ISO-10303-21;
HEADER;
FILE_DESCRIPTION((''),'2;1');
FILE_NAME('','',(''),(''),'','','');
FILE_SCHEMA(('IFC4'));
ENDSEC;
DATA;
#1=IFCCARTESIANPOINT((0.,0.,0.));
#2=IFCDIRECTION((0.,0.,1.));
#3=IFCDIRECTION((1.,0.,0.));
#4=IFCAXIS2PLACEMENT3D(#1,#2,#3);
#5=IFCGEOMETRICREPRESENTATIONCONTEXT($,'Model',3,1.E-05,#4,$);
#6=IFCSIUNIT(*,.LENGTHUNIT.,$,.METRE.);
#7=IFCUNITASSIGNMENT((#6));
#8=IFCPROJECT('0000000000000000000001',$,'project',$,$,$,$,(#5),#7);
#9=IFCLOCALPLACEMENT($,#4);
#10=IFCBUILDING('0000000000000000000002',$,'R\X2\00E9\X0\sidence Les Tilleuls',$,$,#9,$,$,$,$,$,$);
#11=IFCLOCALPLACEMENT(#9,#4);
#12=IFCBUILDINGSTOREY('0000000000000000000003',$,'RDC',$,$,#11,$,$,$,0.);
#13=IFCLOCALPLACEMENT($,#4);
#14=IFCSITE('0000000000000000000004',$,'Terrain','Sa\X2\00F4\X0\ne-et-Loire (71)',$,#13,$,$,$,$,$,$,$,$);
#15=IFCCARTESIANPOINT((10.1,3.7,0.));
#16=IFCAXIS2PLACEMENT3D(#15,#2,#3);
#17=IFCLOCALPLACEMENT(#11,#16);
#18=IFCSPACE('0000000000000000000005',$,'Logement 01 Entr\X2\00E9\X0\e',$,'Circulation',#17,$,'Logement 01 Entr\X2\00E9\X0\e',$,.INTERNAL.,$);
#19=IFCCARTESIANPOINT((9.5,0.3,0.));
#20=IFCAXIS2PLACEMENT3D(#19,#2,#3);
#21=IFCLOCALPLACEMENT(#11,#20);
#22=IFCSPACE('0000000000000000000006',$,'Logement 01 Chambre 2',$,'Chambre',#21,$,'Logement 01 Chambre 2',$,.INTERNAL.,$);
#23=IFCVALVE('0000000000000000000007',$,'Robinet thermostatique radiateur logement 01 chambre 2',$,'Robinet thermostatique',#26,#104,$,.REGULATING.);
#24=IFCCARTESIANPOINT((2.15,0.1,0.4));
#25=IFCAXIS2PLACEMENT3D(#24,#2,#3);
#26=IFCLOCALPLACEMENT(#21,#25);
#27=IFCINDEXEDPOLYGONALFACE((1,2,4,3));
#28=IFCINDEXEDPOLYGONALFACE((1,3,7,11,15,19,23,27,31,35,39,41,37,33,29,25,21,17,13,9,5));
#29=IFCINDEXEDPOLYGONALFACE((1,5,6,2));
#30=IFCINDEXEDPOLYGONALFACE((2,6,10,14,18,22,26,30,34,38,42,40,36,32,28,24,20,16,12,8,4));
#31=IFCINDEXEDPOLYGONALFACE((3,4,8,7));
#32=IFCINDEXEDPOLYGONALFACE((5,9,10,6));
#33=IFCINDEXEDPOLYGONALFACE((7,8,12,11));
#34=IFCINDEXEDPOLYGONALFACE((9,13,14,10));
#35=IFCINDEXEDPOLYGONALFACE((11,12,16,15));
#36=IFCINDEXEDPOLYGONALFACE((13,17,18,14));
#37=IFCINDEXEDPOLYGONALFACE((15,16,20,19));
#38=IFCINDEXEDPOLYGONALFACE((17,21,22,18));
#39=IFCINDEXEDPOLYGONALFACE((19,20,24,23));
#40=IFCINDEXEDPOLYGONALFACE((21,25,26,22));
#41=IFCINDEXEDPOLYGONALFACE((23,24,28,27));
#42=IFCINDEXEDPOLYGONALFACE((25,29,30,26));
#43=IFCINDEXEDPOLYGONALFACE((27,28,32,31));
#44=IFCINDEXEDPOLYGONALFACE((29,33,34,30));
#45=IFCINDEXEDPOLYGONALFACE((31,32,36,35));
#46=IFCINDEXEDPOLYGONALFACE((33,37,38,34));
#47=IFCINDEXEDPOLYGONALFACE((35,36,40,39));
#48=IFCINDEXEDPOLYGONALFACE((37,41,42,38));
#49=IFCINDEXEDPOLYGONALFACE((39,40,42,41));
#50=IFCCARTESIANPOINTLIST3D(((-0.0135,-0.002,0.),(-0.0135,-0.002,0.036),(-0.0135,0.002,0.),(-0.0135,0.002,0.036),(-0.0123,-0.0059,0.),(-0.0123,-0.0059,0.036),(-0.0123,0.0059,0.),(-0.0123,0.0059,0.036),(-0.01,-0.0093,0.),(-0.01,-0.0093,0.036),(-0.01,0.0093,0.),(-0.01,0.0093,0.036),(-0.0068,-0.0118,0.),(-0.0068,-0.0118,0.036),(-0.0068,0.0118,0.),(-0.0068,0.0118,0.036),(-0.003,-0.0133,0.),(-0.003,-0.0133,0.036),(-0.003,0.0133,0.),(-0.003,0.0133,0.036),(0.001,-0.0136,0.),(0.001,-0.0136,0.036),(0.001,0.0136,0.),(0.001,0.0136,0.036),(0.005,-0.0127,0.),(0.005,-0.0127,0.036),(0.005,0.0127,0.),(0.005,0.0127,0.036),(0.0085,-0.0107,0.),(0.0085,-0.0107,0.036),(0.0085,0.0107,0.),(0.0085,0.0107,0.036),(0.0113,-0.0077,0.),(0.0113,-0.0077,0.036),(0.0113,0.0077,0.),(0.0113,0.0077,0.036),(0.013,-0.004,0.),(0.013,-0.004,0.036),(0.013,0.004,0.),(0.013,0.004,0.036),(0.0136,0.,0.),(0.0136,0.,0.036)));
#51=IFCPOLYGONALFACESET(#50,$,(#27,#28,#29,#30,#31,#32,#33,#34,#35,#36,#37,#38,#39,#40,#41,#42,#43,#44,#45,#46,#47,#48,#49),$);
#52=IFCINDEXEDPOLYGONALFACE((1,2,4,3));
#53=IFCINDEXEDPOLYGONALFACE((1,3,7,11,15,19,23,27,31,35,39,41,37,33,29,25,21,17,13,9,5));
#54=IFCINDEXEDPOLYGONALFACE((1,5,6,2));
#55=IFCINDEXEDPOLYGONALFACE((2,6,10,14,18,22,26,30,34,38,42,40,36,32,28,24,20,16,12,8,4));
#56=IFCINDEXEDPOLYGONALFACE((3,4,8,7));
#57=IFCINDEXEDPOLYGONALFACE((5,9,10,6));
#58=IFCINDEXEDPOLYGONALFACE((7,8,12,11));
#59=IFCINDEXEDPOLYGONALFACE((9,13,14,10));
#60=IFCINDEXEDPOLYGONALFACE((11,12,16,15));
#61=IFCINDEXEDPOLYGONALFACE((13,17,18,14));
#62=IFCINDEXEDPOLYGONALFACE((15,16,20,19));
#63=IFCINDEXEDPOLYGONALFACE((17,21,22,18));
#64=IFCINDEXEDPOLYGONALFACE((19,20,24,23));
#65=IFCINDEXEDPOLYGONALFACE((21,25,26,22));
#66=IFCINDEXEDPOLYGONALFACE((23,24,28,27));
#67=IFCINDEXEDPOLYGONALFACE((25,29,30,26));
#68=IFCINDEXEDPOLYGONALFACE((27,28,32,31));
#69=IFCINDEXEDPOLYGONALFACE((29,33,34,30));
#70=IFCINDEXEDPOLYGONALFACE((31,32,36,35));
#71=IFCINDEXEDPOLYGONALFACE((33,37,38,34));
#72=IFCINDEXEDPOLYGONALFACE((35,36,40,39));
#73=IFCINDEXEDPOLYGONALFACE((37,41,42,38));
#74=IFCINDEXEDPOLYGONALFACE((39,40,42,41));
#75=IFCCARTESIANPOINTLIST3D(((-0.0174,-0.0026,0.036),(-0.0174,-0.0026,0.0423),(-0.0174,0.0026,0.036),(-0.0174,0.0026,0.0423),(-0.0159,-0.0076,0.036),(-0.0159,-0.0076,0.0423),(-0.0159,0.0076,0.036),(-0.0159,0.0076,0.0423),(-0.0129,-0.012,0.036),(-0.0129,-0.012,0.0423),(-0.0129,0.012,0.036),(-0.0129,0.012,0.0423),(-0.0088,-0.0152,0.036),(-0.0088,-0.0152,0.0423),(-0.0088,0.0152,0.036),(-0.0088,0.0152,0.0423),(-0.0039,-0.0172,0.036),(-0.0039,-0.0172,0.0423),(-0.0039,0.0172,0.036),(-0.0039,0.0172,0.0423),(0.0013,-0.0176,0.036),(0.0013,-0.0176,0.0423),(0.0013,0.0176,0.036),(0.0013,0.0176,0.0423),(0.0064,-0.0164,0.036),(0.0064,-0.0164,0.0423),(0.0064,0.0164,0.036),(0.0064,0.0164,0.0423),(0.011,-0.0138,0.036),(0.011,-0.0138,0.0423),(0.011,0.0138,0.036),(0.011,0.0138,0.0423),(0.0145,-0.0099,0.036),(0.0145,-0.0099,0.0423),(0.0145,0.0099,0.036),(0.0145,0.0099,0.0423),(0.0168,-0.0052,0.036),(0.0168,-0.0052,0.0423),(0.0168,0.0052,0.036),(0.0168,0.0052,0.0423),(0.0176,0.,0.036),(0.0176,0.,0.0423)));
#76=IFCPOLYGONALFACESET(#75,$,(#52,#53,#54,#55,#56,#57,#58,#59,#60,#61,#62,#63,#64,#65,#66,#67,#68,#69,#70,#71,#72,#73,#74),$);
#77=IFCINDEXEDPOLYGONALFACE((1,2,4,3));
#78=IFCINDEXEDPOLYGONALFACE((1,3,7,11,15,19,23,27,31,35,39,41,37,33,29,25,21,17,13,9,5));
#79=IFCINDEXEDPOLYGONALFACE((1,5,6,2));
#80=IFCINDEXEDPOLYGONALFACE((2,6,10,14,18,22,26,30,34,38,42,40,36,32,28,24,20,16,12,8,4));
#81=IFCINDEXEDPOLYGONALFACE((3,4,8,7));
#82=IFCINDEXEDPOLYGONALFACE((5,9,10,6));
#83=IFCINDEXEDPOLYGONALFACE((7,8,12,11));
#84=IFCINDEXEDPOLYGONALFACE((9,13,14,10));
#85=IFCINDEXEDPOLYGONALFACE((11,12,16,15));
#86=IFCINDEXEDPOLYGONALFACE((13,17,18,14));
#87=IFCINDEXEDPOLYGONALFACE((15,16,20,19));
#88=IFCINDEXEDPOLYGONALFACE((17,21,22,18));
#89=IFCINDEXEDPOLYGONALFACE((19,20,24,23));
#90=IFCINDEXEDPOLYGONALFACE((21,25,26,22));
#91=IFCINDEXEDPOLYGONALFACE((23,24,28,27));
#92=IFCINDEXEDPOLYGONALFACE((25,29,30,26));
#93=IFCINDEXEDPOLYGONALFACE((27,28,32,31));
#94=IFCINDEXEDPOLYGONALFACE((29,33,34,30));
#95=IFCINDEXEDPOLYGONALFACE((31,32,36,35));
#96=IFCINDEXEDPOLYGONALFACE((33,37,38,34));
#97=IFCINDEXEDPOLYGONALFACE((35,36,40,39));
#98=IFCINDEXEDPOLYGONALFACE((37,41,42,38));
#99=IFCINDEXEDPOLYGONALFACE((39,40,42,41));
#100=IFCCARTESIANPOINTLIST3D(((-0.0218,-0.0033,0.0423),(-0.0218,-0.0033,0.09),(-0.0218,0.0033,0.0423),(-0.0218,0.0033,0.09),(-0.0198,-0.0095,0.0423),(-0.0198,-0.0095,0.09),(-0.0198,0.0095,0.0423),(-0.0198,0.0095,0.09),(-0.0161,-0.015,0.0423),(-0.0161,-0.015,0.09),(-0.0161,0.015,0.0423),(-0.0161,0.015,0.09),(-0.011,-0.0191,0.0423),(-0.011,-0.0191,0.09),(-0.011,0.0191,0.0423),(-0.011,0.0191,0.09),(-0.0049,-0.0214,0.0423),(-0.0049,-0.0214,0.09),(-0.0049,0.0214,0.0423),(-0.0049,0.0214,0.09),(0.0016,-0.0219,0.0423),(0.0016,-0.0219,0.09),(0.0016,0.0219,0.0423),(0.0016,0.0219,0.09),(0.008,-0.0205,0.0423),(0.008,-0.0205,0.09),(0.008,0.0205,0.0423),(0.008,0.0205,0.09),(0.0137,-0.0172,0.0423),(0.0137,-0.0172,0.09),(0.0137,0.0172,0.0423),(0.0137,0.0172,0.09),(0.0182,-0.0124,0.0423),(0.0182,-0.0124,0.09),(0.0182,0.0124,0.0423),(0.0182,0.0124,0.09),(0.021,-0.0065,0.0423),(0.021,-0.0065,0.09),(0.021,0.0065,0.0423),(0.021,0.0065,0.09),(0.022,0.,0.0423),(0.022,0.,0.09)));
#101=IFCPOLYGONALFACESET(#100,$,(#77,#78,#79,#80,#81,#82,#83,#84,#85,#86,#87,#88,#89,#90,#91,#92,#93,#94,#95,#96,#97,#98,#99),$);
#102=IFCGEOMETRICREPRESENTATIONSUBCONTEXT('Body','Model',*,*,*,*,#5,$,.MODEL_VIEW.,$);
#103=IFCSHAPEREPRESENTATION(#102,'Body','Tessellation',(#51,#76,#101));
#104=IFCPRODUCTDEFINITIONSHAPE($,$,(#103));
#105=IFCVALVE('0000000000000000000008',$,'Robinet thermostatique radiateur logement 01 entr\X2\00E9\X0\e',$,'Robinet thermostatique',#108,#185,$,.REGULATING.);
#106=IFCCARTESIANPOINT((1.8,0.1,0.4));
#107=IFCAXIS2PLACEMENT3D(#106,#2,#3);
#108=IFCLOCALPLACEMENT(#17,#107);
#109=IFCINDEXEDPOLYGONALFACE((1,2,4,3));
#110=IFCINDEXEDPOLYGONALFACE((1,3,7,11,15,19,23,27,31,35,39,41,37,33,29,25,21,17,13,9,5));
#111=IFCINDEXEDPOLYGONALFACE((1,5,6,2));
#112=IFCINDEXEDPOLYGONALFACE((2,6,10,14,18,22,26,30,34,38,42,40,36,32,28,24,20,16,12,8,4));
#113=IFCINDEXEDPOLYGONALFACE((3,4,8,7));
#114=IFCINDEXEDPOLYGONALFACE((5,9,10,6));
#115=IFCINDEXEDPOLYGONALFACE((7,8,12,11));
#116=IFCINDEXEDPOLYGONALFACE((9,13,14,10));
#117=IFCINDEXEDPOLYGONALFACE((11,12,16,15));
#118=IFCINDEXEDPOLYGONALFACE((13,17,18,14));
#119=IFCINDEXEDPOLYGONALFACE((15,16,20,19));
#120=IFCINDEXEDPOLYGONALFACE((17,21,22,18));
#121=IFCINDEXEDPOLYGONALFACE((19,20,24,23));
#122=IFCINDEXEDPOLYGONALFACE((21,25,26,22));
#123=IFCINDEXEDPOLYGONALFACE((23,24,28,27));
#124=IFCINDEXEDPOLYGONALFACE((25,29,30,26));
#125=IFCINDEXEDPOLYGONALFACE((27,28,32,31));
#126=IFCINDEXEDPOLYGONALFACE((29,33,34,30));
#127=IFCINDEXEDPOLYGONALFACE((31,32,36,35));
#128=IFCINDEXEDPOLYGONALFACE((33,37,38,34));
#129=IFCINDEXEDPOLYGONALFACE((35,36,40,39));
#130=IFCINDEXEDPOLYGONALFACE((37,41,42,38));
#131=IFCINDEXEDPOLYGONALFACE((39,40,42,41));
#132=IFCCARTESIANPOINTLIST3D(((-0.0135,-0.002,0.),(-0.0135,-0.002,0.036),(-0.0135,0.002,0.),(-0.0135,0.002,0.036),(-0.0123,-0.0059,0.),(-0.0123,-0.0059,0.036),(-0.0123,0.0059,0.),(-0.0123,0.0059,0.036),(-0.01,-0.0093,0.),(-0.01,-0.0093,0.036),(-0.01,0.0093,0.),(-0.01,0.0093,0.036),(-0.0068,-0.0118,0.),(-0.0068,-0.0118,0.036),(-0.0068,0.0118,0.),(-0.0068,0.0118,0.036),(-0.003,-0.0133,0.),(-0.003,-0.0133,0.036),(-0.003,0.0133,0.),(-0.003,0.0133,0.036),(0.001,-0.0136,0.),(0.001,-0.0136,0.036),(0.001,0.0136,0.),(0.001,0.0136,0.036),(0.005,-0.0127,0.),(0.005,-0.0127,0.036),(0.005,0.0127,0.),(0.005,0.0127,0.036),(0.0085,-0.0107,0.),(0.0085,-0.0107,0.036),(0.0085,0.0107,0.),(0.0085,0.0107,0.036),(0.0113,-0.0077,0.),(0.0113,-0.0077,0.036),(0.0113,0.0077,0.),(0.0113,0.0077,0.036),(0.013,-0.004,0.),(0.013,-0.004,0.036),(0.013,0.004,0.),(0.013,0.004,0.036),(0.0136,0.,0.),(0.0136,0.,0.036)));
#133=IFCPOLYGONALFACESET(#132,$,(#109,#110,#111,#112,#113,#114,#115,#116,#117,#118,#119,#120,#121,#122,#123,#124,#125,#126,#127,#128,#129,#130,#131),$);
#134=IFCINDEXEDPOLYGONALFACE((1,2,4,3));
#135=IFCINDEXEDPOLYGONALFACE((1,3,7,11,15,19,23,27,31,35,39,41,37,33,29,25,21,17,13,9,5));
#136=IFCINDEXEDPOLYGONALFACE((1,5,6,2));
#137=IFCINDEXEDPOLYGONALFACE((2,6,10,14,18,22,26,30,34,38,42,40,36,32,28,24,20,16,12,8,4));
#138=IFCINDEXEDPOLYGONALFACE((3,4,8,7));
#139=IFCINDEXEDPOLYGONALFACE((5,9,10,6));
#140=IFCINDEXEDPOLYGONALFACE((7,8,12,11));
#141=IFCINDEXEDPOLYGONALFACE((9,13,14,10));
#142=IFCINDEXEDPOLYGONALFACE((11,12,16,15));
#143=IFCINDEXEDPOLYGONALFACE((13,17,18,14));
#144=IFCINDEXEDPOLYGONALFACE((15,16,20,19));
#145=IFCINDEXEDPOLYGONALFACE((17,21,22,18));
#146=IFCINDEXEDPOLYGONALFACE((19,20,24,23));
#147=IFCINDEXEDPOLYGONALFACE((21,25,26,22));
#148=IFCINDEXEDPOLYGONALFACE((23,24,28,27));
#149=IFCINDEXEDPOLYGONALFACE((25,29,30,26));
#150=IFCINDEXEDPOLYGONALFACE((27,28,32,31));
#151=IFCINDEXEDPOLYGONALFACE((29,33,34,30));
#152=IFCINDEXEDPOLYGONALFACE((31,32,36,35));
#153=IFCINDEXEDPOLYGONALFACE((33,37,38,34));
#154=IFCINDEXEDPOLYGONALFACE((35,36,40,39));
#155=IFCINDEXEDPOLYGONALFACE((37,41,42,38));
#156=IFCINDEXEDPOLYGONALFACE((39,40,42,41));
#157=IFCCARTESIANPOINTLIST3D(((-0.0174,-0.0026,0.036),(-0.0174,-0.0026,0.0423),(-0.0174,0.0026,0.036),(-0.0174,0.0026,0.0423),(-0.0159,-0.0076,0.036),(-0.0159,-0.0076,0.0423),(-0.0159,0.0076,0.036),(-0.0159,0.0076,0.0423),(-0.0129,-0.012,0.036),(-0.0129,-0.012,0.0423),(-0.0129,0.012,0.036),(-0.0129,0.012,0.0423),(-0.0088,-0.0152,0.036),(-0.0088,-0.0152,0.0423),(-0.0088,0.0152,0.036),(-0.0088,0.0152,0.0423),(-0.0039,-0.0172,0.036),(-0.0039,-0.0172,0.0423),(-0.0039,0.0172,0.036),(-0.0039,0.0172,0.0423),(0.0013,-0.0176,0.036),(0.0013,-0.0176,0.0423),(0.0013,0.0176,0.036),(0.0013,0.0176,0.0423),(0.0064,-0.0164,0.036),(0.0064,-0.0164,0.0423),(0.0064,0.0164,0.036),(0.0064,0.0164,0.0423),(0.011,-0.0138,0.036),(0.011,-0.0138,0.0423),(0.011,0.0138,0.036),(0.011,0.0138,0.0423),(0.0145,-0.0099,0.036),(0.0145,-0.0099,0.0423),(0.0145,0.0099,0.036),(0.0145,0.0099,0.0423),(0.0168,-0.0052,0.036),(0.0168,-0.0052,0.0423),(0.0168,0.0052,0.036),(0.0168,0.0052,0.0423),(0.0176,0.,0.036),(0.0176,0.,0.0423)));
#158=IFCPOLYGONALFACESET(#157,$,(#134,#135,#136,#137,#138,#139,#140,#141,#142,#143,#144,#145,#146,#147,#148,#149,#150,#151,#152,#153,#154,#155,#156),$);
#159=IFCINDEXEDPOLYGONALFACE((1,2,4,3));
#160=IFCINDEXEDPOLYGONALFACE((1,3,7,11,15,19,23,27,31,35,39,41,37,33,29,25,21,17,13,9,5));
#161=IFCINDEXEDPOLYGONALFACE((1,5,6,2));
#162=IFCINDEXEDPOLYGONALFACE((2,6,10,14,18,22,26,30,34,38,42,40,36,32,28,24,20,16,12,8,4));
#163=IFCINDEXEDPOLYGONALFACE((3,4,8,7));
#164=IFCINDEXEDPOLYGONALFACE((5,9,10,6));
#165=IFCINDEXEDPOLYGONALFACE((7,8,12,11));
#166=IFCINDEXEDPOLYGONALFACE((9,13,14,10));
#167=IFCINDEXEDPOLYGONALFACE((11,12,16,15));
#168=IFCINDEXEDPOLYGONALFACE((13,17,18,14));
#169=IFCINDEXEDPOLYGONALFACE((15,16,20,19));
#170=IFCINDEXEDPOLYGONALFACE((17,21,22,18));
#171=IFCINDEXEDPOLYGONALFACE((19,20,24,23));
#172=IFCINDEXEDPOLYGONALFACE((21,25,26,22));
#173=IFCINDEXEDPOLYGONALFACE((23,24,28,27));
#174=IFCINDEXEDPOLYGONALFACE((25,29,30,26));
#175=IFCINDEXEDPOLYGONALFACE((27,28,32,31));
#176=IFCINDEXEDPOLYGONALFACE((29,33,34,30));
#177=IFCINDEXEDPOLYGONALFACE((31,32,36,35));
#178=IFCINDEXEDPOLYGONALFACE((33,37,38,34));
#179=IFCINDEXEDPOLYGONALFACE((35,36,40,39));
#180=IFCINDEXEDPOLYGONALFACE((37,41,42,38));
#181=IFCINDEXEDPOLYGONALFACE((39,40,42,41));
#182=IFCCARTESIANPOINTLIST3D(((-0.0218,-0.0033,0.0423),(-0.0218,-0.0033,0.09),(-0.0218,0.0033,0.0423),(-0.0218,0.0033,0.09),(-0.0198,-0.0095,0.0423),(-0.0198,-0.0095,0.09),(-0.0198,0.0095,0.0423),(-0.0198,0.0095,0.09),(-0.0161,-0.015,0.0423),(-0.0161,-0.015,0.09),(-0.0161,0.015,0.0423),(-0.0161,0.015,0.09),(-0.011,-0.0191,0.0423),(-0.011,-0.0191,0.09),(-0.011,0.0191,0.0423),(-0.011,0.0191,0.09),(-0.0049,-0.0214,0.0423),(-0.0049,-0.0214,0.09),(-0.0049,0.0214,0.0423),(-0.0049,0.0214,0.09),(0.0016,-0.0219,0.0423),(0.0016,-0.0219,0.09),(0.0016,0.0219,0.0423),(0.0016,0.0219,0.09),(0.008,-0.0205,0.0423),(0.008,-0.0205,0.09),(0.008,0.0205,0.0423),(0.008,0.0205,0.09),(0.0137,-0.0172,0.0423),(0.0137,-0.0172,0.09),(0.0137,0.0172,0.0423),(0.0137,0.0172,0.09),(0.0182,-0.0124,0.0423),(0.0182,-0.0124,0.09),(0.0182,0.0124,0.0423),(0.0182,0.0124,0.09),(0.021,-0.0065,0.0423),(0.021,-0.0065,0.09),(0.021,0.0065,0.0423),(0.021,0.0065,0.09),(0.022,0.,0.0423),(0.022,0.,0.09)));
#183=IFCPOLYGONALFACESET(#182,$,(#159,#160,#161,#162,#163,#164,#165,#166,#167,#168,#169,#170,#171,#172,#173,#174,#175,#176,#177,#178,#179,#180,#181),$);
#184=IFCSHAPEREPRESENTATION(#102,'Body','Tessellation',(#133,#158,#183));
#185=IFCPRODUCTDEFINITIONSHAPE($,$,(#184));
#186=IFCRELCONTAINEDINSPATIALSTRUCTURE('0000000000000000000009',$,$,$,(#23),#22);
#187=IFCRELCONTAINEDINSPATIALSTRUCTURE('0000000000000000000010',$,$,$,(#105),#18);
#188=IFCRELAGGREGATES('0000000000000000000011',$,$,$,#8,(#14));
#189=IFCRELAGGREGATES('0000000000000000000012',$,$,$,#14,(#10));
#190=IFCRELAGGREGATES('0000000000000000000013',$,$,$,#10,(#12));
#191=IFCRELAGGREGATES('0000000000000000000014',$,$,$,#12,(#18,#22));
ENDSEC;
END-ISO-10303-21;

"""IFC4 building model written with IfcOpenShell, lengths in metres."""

from ifc_helpers import new_model, si_unit, frame, origin_with_axes, place, context, subcontext, project, spatial, circle, extrude, element, save


model = new_model("IFC4")

# Units and contexts
model_context = context("Model", 3, precision=1e-05, world=origin_with_axes())
body_context = subcontext(model_context, "Body", "Model", "MODEL_VIEW")
ifc_project = project(units=[si_unit("LENGTHUNIT", "METRE")], contexts=[model_context])

# Site, building, storey
site_placement = place(None, origin_with_axes())
site = spatial("IfcSite", under=ifc_project, at=site_placement, Name="Terrain", Description="Saône-et-Loire (71)")
building_placement = place(None, origin_with_axes())
building = spatial("IfcBuilding", under=site, at=building_placement, Name="Résidence Les Tilleuls")
storey_placement = place(building_placement, origin_with_axes())
storey = spatial("IfcBuildingStorey", under=building, at=storey_placement, Name="RDC", Elevation=0.0)

# Shared definitions
space_1_placement = place(storey_placement, frame((10.1, 3.7, 0.0), z_axis=(0.0, 0.0, 1.0), x_axis=(1.0, 0.0, 0.0)))
space_1 = spatial("IfcSpace", under=storey, at=space_1_placement, Name="Logement 01 Entrée", ObjectType="Circulation", LongName="Logement 01 Entrée", PredefinedType="INTERNAL")

# Shared definitions
space_2_placement = place(storey_placement, frame((9.5, 0.3, 0.0), z_axis=(0.0, 0.0, 1.0), x_axis=(1.0, 0.0, 0.0)))
space_2 = spatial("IfcSpace", under=storey, at=space_2_placement, Name="Logement 01 Chambre 2", ObjectType="Chambre", LongName="Logement 01 Chambre 2", PredefinedType="INTERNAL")

# Valve
valve_1_placement = place(space_2_placement, frame((2.15, 0.1, 0.4), z_axis=(0.0, 0.0, 1.0), x_axis=(1.0, 0.0, 0.0)))
element("IfcValve", 1, at=valve_1_placement, inside=space_2, Name="Robinet thermostatique radiateur logement 01 chambre 2", ObjectType="Robinet thermostatique", PredefinedType="REGULATING", context=body_context, shape_type="SweptSolid", body=[
    extrude(circle(Radius=0.0136), origin_with_axes(), (0.0, 0.0, 1.0), 0.036),
    extrude(circle(Radius=0.0176), frame((0.0, 0.0, 0.036), z_axis=(0.0, 0.0, 1.0), x_axis=(1.0, 0.0, 0.0)), (0.0, 0.0, 1.0), 0.0063),
    extrude(circle(Radius=0.022), frame((0.0, 0.0, 0.0423), z_axis=(0.0, 0.0, 1.0), x_axis=(1.0, 0.0, 0.0)), (0.0, 0.0, 1.0), 0.0477),
])

# Valve
valve_2_placement = place(space_1_placement, frame((1.8, 0.1, 0.4), z_axis=(0.0, 0.0, 1.0), x_axis=(1.0, 0.0, 0.0)))
element("IfcValve", 2, at=valve_2_placement, inside=space_1, Name="Robinet thermostatique radiateur logement 01 entrée", ObjectType="Robinet thermostatique", PredefinedType="REGULATING", context=body_context, shape_type="SweptSolid", body=[
    extrude(circle(Radius=0.0136), origin_with_axes(), (0.0, 0.0, 1.0), 0.036),
    extrude(circle(Radius=0.0176), frame((0.0, 0.0, 0.036), z_axis=(0.0, 0.0, 1.0), x_axis=(1.0, 0.0, 0.0)), (0.0, 0.0, 1.0), 0.0063),
    extrude(circle(Radius=0.022), frame((0.0, 0.0, 0.0423), z_axis=(0.0, 0.0, 1.0), x_axis=(1.0, 0.0, 0.0)), (0.0, 0.0, 1.0), 0.0477),
])

save(model, "model.ifc")
